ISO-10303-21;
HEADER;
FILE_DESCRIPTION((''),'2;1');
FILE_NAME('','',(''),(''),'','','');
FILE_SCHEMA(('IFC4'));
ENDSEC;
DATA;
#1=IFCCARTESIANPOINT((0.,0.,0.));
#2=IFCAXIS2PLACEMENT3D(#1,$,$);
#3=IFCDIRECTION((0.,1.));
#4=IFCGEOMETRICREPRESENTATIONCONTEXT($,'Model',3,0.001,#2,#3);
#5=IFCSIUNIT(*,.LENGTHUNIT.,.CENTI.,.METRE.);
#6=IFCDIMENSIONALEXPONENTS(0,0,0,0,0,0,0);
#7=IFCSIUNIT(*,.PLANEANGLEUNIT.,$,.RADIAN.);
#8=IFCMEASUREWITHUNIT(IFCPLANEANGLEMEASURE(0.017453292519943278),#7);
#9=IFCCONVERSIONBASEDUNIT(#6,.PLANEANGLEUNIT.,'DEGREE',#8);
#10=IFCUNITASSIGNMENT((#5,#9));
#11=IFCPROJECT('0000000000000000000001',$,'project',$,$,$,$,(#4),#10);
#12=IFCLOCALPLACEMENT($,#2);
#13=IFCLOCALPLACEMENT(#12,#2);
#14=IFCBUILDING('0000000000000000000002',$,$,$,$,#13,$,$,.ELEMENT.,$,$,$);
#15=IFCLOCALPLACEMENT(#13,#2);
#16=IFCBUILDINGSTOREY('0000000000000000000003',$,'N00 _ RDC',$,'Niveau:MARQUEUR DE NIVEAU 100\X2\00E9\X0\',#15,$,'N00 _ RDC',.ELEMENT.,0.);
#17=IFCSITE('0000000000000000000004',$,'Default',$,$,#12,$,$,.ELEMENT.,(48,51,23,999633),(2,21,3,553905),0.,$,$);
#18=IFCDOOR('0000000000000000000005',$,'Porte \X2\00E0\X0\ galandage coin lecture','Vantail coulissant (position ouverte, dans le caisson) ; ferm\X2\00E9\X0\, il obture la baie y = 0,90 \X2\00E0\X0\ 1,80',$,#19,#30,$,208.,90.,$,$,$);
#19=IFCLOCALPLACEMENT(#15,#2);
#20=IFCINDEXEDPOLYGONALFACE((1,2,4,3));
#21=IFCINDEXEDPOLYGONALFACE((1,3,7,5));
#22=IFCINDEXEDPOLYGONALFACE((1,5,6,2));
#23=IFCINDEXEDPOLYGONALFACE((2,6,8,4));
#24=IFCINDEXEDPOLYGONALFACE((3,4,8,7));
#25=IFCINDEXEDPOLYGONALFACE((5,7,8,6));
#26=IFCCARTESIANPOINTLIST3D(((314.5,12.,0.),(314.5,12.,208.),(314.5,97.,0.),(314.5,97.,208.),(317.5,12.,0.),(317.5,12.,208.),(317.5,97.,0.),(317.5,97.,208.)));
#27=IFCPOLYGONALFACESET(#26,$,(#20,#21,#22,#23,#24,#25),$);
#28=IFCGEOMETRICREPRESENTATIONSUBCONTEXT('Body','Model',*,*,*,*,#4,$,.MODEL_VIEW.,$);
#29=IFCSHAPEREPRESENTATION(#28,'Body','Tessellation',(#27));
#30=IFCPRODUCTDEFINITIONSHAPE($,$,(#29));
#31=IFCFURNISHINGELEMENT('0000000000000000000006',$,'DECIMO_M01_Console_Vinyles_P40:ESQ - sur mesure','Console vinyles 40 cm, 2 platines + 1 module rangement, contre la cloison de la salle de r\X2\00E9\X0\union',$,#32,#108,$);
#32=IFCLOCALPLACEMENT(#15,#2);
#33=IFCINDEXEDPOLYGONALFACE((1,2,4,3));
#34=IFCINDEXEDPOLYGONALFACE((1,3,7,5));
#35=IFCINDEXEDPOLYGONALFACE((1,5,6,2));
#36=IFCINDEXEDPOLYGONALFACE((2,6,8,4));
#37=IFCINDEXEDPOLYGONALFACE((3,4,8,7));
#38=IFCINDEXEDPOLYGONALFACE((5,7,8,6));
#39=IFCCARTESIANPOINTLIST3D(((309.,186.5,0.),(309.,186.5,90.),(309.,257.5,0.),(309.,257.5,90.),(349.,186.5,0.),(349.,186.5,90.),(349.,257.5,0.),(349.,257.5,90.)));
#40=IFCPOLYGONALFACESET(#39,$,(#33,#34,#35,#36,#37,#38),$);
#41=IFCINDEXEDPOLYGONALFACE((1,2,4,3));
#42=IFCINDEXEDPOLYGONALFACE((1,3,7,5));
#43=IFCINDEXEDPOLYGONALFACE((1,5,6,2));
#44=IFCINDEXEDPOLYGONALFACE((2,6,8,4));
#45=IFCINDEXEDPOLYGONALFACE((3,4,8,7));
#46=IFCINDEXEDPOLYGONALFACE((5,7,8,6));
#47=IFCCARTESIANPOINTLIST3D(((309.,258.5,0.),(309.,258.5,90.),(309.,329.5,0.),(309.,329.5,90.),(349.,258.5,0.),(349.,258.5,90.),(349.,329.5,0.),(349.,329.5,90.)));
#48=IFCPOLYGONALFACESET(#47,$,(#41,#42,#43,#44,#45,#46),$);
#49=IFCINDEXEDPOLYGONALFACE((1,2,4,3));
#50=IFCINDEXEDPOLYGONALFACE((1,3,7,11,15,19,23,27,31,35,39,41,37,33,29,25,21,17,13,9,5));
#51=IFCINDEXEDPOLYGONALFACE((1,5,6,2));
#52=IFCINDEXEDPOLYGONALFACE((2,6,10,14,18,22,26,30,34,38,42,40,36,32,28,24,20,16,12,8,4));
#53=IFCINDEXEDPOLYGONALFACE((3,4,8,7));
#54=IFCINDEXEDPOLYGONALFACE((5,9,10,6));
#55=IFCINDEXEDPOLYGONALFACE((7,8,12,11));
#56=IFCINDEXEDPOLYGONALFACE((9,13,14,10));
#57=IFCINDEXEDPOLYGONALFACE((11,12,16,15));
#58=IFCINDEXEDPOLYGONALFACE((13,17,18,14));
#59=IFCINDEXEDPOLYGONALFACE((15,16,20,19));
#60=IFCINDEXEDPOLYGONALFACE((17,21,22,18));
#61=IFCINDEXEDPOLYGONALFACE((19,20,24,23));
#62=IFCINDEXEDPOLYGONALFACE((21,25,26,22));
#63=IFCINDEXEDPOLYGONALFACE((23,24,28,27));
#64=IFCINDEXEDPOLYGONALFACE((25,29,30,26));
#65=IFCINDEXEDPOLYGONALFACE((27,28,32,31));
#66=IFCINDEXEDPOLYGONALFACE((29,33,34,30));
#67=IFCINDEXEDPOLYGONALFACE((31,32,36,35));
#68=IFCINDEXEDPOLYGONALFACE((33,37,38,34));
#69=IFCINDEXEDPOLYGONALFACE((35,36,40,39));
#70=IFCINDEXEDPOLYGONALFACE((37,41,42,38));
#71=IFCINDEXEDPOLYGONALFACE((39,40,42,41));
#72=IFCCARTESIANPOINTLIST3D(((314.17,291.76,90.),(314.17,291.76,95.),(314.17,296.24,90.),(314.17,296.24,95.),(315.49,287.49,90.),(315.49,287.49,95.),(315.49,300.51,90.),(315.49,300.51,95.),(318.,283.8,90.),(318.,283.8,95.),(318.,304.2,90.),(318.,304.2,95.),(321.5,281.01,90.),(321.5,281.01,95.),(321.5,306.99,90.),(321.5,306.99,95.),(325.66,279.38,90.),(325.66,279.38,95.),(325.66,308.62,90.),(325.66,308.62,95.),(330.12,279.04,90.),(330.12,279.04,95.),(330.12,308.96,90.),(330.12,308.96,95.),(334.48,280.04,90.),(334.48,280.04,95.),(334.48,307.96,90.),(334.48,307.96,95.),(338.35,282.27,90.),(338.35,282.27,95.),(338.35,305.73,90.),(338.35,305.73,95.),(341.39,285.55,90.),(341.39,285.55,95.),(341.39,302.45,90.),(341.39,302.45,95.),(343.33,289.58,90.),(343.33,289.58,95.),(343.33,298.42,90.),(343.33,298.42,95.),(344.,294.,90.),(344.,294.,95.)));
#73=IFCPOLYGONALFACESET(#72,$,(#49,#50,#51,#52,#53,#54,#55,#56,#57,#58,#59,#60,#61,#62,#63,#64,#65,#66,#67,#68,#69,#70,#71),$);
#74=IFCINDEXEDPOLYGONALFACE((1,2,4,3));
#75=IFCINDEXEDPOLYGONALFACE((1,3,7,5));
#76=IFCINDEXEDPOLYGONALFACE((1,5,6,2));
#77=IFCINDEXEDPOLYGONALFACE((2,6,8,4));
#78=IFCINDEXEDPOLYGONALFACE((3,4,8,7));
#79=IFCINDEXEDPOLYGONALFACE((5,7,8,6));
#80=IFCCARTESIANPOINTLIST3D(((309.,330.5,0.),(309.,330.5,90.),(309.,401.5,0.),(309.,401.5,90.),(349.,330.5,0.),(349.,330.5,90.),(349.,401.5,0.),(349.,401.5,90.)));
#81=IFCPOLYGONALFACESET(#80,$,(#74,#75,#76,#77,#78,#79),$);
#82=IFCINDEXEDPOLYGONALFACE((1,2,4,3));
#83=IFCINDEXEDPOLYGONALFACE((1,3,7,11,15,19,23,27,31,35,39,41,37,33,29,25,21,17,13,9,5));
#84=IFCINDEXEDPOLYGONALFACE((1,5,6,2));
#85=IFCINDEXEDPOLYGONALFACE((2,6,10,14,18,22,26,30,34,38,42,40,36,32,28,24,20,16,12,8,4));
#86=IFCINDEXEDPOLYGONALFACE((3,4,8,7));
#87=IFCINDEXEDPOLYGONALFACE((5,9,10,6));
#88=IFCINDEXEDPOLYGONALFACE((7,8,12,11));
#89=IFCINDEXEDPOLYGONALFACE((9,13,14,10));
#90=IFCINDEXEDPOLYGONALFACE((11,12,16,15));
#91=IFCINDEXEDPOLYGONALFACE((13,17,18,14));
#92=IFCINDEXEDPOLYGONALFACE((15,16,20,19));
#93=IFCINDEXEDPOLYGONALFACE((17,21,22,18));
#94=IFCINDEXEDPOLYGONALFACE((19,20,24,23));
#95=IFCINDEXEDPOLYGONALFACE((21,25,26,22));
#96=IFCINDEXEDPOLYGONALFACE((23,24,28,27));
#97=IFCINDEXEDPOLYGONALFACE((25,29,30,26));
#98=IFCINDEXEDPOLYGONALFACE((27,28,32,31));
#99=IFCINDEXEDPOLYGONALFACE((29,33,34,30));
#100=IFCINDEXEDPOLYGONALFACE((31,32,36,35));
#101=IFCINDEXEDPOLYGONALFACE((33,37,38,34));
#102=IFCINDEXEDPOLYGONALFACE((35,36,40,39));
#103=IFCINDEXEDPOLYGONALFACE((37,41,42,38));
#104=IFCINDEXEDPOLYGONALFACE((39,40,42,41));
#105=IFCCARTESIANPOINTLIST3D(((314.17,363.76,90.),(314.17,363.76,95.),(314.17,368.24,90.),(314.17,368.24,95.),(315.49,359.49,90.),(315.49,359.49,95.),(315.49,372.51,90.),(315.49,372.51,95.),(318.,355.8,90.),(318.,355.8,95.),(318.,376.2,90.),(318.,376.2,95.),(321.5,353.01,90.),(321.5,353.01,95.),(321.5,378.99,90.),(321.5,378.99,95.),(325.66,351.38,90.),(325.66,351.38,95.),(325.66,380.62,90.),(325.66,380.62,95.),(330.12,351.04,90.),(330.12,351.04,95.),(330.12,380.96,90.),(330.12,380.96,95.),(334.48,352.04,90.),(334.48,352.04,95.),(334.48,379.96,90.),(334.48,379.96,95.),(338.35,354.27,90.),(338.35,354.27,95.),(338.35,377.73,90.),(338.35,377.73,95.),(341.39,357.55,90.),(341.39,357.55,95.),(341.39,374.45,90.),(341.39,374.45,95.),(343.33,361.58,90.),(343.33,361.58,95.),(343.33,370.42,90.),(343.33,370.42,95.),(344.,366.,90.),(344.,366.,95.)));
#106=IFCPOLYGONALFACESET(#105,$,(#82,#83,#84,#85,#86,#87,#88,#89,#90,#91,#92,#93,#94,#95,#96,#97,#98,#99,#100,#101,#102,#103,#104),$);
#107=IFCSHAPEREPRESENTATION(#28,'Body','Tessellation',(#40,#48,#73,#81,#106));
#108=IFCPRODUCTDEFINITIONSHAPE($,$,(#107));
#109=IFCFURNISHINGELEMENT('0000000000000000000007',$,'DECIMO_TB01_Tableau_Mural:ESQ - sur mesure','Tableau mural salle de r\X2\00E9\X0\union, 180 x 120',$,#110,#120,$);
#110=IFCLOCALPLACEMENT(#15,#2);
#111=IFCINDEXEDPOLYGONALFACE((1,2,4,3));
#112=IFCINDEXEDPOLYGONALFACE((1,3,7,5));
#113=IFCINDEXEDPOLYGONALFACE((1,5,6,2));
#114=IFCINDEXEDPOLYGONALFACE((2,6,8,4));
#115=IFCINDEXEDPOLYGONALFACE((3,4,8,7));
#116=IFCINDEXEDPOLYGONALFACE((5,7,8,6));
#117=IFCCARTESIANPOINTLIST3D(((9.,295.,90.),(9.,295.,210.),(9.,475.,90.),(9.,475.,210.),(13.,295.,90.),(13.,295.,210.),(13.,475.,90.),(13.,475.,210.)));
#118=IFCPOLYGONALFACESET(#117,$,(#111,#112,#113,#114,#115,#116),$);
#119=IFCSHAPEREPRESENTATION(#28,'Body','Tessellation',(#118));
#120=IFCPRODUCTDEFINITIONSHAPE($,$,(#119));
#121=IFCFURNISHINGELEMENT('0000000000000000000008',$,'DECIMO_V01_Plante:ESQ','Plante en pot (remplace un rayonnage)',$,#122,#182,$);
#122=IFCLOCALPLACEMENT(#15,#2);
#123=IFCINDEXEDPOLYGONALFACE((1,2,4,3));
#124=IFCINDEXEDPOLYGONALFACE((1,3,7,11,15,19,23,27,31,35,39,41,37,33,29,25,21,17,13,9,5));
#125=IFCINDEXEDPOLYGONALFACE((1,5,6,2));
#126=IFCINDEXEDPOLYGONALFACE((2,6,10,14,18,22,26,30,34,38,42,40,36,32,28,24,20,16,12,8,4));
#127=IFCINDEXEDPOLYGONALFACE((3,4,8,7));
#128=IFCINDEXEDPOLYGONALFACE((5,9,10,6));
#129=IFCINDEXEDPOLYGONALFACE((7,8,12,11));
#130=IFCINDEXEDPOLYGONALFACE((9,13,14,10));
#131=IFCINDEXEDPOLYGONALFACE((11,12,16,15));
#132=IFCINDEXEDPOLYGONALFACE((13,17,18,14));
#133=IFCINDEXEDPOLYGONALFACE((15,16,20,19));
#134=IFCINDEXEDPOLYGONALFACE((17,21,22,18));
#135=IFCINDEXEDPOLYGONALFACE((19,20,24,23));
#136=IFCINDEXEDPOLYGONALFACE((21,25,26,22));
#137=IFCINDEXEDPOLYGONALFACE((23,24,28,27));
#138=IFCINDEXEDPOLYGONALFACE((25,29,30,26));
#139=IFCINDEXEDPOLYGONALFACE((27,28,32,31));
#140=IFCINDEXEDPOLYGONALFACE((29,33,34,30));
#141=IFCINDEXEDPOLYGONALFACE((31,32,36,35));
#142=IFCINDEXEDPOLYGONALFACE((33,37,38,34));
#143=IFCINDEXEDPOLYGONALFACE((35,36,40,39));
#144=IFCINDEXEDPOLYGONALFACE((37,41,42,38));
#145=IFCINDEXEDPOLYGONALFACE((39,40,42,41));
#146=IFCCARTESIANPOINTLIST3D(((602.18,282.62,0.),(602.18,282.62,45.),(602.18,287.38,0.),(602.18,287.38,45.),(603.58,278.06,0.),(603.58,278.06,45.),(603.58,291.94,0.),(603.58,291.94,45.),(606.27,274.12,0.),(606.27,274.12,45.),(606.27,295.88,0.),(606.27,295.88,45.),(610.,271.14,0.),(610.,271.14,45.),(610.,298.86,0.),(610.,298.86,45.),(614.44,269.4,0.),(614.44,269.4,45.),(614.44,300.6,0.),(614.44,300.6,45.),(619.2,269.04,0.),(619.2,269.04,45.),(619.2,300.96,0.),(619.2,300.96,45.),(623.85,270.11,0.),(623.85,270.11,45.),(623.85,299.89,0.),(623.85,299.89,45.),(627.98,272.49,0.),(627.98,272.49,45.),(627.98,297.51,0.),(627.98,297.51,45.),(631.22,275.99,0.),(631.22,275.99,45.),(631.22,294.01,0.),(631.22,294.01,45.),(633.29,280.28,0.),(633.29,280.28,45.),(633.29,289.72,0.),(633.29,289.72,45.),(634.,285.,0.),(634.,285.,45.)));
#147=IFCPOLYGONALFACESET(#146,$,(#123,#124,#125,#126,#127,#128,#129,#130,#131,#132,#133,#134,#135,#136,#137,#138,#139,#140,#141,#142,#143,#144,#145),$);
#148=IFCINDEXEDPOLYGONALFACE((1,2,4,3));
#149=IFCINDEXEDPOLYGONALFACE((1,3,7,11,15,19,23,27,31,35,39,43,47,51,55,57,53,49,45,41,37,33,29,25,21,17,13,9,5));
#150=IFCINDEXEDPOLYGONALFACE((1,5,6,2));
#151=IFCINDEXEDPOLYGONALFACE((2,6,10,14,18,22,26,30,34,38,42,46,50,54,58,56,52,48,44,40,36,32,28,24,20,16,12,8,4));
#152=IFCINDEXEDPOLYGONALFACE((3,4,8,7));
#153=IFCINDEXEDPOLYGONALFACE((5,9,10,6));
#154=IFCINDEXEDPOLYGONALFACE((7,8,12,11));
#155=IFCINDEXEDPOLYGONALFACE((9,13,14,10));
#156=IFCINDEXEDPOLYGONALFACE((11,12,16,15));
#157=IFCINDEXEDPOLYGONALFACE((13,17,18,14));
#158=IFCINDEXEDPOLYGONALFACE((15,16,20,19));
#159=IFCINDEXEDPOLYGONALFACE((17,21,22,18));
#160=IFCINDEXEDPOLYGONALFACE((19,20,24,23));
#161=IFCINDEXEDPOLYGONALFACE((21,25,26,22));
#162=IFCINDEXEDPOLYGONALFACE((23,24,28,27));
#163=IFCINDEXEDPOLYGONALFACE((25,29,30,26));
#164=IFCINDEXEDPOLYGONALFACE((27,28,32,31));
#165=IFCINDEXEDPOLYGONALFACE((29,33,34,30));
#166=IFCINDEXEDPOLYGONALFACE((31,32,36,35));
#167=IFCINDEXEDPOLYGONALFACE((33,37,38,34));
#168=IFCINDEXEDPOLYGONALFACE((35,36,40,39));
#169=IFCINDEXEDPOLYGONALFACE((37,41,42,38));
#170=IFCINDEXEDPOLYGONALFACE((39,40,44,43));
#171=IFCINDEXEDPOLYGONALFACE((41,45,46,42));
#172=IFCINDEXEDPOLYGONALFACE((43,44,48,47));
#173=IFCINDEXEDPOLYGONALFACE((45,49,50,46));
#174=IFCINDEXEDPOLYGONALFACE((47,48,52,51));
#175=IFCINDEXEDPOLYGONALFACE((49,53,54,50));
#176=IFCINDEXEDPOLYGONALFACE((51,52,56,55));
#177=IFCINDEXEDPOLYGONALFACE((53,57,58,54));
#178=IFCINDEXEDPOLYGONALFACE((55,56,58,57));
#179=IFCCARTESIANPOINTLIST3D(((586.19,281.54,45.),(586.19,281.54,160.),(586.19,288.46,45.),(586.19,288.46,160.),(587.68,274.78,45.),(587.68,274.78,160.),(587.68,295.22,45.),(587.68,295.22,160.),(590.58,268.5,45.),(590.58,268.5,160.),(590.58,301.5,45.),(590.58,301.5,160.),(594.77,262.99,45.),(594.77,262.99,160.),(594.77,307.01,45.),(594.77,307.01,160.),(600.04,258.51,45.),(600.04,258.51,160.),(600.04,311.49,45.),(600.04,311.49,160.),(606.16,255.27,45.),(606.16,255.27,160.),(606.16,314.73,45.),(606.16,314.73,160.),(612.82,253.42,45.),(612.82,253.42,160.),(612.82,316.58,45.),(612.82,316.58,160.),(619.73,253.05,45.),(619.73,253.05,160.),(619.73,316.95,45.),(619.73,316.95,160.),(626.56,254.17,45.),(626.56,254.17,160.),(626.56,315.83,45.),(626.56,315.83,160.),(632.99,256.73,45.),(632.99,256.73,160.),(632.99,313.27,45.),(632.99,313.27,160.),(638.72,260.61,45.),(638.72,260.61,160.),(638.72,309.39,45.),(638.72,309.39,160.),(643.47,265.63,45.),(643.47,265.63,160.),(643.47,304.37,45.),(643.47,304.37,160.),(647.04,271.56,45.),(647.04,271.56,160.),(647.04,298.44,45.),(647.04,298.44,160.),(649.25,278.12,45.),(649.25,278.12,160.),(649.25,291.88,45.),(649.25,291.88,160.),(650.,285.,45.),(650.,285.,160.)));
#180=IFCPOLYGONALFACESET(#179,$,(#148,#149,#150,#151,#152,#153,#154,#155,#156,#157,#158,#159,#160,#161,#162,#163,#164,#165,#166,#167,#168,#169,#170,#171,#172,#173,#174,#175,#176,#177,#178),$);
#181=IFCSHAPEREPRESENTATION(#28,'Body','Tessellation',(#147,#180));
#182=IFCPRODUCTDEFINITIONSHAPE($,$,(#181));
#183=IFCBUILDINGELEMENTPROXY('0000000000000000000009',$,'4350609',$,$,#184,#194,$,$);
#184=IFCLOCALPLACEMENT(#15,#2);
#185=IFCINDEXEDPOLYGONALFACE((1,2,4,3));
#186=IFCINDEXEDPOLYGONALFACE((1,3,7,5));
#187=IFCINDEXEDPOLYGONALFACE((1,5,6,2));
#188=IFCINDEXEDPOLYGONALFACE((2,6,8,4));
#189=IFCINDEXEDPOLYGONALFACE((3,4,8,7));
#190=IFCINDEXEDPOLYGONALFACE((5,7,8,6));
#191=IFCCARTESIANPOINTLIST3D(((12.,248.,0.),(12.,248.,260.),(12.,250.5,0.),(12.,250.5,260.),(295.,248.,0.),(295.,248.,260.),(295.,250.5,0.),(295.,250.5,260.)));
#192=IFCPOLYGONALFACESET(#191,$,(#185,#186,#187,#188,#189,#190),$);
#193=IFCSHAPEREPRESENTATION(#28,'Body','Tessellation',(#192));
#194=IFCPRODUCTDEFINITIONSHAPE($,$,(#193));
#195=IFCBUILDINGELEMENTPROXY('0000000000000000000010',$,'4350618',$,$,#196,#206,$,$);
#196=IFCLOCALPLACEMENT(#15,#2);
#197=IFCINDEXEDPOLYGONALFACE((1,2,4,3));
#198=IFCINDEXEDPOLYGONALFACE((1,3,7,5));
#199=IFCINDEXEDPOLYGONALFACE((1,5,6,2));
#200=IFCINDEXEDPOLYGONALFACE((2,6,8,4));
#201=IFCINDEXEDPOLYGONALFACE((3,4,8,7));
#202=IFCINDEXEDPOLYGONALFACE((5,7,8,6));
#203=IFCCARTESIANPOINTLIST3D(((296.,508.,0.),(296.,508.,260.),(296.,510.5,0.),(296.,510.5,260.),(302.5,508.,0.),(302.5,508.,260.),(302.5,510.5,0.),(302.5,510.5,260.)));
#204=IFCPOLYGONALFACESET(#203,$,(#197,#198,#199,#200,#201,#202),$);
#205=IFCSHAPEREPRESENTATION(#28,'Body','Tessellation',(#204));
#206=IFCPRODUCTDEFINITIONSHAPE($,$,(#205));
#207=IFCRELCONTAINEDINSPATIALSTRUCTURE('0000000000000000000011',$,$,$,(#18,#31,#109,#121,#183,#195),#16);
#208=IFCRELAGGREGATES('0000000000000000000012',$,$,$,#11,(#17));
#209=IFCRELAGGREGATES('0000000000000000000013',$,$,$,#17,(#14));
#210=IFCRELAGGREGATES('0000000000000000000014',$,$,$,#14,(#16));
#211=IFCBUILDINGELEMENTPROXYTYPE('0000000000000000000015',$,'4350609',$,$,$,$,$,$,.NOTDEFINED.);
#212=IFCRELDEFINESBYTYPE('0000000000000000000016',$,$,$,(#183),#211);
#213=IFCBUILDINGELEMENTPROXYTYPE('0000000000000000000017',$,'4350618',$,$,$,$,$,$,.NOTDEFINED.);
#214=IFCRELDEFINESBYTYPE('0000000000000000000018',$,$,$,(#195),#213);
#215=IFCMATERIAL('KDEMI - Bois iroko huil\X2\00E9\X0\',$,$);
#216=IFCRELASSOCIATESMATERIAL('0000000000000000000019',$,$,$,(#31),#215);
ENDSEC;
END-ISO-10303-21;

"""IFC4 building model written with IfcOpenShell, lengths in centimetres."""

from ifc_helpers import new_model, entity, si_unit, converted_unit, direction, frame, frame_2d, origin, origin_with_axes, place, context, subcontext, project, spatial, rectangle, circle, extrude, material, type_object, element, save


model = new_model("IFC4")

# Units and contexts
model_context = context("Model", 3, precision=0.001, world=origin(), true_north=direction((0.0, 1.0)))
body_context = subcontext(model_context, "Body", "Model", "MODEL_VIEW")
ifc_project = project(units=[si_unit("LENGTHUNIT", "METRE", prefix="CENTI"), converted_unit("PLANEANGLEUNIT", "DEGREE", entity("IfcPlaneAngleMeasure", 0.017453292519943278), si_unit("PLANEANGLEUNIT", "RADIAN"), dimensions=[0, 0, 0, 0, 0, 0, 0])], contexts=[model_context])

# Site, building, storey
site_placement = place(None, origin())
site = spatial("IfcSite", under=ifc_project, at=site_placement, Name="Default", CompositionType="ELEMENT", RefLatitude=(48, 51, 23, 999633), RefLongitude=(2, 21, 3, 553905), RefElevation=0.0)
building_placement = place(site_placement, origin())
building = spatial("IfcBuilding", under=site, at=building_placement, CompositionType="ELEMENT")
storey_placement = place(building_placement, origin())
storey = spatial("IfcBuildingStorey", under=building, at=storey_placement, Name="N00 _ RDC", ObjectType="Niveau:MARQUEUR DE NIVEAU 100é", LongName="N00 _ RDC", CompositionType="ELEMENT", Elevation=0.0)

# Door
door_placement = place(storey_placement, origin_with_axes())
element("IfcDoor", 1, at=door_placement, inside=storey, Name="Porte à galandage coin lecture", Description="Vantail coulissant (position ouverte, dans le caisson) ; fermé, il obture la baie y = 0,90 à 1,80", OverallHeight=208.0, OverallWidth=90.0, context=body_context, shape_type="SweptSolid", body=[
    extrude(rectangle(XDim=3.0, YDim=85.0, at=frame_2d((316.0, 54.5))), origin(), (0.0, 0.0, 1.0), 208.0),
])

# Furnishing elements
ifc_material = material(Name="KDEMI - Bois iroko huilé")
furnishing_1_placement = place(storey_placement, origin_with_axes())
element("IfcFurnishingElement", 2, at=furnishing_1_placement, inside=storey, material=ifc_material, Name="DECIMO_M01_Console_Vinyles_P40:ESQ - sur mesure", Description="Console vinyles 40 cm, 2 platines + 1 module rangement, contre la cloison de la salle de réunion", context=body_context, shape_type="SweptSolid", body=[
    extrude(rectangle(XDim=40.0, YDim=71.0, at=frame_2d((329.0, 222.0))), origin(), (0.0, 0.0, 1.0), 90.0),
    extrude(rectangle(XDim=40.0, YDim=71.0, at=frame_2d((329.0, 294.0))), origin(), (0.0, 0.0, 1.0), 90.0),
    extrude(circle(Radius=15.0, at=frame_2d((329.0, 294.0))), frame((0.0, 0.0, 90.0)), (0.0, 0.0, 1.0), 5.0),
    extrude(rectangle(XDim=40.0, YDim=71.0, at=frame_2d((329.0, 366.0))), origin(), (0.0, 0.0, 1.0), 90.0),
    extrude(circle(Radius=15.0, at=frame_2d((329.0, 366.0))), frame((0.0, 0.0, 90.0)), (0.0, 0.0, 1.0), 5.0),
])
furnishing_2_placement = place(storey_placement, origin_with_axes())
element("IfcFurnishingElement", 3, at=furnishing_2_placement, inside=storey, Name="DECIMO_TB01_Tableau_Mural:ESQ - sur mesure", Description="Tableau mural salle de réunion, 180 x 120", context=body_context, shape_type="SweptSolid", body=[
    extrude(rectangle(XDim=4.0, YDim=180.0, at=frame_2d((11.0, 385.0))), frame((0.0, 0.0, 90.0)), (0.0, 0.0, 1.0), 120.0),
])
furnishing_3_placement = place(storey_placement, origin_with_axes())
element("IfcFurnishingElement", 4, at=furnishing_3_placement, inside=storey, Name="DECIMO_V01_Plante:ESQ", Description="Plante en pot (remplace un rayonnage)", context=body_context, shape_type="SweptSolid", body=[
    extrude(circle(Radius=16.0, at=frame_2d((618.0, 285.0))), origin(), (0.0, 0.0, 1.0), 45.0),
    extrude(circle(Radius=32.0, at=frame_2d((618.0, 285.0))), frame((0.0, 0.0, 45.0)), (0.0, 0.0, 1.0), 115.0),
])

# Building element proxies
building_element_proxy_type_1 = type_object("IfcBuildingElementProxyType", Name="4350609", PredefinedType="NOTDEFINED")
proxy_1_placement = place(storey_placement, origin())
element("IfcBuildingElementProxy", 5, at=proxy_1_placement, inside=storey, type_object=building_element_proxy_type_1, Name="4350609", context=body_context, shape_type="SweptSolid", body=[
    extrude(rectangle(XDim=283.0, YDim=2.5, at=frame_2d((0.0, 0.0), x_axis=(1.0, 0.0))), frame((153.5, 249.25, 0.0)), (0.0, 0.0, 1.0), 260.0),
])
building_element_proxy_type_2 = type_object("IfcBuildingElementProxyType", Name="4350618", PredefinedType="NOTDEFINED")
proxy_2_placement = place(storey_placement, origin())
element("IfcBuildingElementProxy", 6, at=proxy_2_placement, inside=storey, type_object=building_element_proxy_type_2, Name="4350618", context=body_context, shape_type="SweptSolid", body=[
    extrude(rectangle(XDim=6.5, YDim=2.5, at=frame_2d((0.0, 0.0), x_axis=(1.0, 0.0))), frame((299.25, 509.25, 0.0)), (0.0, 0.0, 1.0), 260.0),
])

save(model, "model.ifc")
